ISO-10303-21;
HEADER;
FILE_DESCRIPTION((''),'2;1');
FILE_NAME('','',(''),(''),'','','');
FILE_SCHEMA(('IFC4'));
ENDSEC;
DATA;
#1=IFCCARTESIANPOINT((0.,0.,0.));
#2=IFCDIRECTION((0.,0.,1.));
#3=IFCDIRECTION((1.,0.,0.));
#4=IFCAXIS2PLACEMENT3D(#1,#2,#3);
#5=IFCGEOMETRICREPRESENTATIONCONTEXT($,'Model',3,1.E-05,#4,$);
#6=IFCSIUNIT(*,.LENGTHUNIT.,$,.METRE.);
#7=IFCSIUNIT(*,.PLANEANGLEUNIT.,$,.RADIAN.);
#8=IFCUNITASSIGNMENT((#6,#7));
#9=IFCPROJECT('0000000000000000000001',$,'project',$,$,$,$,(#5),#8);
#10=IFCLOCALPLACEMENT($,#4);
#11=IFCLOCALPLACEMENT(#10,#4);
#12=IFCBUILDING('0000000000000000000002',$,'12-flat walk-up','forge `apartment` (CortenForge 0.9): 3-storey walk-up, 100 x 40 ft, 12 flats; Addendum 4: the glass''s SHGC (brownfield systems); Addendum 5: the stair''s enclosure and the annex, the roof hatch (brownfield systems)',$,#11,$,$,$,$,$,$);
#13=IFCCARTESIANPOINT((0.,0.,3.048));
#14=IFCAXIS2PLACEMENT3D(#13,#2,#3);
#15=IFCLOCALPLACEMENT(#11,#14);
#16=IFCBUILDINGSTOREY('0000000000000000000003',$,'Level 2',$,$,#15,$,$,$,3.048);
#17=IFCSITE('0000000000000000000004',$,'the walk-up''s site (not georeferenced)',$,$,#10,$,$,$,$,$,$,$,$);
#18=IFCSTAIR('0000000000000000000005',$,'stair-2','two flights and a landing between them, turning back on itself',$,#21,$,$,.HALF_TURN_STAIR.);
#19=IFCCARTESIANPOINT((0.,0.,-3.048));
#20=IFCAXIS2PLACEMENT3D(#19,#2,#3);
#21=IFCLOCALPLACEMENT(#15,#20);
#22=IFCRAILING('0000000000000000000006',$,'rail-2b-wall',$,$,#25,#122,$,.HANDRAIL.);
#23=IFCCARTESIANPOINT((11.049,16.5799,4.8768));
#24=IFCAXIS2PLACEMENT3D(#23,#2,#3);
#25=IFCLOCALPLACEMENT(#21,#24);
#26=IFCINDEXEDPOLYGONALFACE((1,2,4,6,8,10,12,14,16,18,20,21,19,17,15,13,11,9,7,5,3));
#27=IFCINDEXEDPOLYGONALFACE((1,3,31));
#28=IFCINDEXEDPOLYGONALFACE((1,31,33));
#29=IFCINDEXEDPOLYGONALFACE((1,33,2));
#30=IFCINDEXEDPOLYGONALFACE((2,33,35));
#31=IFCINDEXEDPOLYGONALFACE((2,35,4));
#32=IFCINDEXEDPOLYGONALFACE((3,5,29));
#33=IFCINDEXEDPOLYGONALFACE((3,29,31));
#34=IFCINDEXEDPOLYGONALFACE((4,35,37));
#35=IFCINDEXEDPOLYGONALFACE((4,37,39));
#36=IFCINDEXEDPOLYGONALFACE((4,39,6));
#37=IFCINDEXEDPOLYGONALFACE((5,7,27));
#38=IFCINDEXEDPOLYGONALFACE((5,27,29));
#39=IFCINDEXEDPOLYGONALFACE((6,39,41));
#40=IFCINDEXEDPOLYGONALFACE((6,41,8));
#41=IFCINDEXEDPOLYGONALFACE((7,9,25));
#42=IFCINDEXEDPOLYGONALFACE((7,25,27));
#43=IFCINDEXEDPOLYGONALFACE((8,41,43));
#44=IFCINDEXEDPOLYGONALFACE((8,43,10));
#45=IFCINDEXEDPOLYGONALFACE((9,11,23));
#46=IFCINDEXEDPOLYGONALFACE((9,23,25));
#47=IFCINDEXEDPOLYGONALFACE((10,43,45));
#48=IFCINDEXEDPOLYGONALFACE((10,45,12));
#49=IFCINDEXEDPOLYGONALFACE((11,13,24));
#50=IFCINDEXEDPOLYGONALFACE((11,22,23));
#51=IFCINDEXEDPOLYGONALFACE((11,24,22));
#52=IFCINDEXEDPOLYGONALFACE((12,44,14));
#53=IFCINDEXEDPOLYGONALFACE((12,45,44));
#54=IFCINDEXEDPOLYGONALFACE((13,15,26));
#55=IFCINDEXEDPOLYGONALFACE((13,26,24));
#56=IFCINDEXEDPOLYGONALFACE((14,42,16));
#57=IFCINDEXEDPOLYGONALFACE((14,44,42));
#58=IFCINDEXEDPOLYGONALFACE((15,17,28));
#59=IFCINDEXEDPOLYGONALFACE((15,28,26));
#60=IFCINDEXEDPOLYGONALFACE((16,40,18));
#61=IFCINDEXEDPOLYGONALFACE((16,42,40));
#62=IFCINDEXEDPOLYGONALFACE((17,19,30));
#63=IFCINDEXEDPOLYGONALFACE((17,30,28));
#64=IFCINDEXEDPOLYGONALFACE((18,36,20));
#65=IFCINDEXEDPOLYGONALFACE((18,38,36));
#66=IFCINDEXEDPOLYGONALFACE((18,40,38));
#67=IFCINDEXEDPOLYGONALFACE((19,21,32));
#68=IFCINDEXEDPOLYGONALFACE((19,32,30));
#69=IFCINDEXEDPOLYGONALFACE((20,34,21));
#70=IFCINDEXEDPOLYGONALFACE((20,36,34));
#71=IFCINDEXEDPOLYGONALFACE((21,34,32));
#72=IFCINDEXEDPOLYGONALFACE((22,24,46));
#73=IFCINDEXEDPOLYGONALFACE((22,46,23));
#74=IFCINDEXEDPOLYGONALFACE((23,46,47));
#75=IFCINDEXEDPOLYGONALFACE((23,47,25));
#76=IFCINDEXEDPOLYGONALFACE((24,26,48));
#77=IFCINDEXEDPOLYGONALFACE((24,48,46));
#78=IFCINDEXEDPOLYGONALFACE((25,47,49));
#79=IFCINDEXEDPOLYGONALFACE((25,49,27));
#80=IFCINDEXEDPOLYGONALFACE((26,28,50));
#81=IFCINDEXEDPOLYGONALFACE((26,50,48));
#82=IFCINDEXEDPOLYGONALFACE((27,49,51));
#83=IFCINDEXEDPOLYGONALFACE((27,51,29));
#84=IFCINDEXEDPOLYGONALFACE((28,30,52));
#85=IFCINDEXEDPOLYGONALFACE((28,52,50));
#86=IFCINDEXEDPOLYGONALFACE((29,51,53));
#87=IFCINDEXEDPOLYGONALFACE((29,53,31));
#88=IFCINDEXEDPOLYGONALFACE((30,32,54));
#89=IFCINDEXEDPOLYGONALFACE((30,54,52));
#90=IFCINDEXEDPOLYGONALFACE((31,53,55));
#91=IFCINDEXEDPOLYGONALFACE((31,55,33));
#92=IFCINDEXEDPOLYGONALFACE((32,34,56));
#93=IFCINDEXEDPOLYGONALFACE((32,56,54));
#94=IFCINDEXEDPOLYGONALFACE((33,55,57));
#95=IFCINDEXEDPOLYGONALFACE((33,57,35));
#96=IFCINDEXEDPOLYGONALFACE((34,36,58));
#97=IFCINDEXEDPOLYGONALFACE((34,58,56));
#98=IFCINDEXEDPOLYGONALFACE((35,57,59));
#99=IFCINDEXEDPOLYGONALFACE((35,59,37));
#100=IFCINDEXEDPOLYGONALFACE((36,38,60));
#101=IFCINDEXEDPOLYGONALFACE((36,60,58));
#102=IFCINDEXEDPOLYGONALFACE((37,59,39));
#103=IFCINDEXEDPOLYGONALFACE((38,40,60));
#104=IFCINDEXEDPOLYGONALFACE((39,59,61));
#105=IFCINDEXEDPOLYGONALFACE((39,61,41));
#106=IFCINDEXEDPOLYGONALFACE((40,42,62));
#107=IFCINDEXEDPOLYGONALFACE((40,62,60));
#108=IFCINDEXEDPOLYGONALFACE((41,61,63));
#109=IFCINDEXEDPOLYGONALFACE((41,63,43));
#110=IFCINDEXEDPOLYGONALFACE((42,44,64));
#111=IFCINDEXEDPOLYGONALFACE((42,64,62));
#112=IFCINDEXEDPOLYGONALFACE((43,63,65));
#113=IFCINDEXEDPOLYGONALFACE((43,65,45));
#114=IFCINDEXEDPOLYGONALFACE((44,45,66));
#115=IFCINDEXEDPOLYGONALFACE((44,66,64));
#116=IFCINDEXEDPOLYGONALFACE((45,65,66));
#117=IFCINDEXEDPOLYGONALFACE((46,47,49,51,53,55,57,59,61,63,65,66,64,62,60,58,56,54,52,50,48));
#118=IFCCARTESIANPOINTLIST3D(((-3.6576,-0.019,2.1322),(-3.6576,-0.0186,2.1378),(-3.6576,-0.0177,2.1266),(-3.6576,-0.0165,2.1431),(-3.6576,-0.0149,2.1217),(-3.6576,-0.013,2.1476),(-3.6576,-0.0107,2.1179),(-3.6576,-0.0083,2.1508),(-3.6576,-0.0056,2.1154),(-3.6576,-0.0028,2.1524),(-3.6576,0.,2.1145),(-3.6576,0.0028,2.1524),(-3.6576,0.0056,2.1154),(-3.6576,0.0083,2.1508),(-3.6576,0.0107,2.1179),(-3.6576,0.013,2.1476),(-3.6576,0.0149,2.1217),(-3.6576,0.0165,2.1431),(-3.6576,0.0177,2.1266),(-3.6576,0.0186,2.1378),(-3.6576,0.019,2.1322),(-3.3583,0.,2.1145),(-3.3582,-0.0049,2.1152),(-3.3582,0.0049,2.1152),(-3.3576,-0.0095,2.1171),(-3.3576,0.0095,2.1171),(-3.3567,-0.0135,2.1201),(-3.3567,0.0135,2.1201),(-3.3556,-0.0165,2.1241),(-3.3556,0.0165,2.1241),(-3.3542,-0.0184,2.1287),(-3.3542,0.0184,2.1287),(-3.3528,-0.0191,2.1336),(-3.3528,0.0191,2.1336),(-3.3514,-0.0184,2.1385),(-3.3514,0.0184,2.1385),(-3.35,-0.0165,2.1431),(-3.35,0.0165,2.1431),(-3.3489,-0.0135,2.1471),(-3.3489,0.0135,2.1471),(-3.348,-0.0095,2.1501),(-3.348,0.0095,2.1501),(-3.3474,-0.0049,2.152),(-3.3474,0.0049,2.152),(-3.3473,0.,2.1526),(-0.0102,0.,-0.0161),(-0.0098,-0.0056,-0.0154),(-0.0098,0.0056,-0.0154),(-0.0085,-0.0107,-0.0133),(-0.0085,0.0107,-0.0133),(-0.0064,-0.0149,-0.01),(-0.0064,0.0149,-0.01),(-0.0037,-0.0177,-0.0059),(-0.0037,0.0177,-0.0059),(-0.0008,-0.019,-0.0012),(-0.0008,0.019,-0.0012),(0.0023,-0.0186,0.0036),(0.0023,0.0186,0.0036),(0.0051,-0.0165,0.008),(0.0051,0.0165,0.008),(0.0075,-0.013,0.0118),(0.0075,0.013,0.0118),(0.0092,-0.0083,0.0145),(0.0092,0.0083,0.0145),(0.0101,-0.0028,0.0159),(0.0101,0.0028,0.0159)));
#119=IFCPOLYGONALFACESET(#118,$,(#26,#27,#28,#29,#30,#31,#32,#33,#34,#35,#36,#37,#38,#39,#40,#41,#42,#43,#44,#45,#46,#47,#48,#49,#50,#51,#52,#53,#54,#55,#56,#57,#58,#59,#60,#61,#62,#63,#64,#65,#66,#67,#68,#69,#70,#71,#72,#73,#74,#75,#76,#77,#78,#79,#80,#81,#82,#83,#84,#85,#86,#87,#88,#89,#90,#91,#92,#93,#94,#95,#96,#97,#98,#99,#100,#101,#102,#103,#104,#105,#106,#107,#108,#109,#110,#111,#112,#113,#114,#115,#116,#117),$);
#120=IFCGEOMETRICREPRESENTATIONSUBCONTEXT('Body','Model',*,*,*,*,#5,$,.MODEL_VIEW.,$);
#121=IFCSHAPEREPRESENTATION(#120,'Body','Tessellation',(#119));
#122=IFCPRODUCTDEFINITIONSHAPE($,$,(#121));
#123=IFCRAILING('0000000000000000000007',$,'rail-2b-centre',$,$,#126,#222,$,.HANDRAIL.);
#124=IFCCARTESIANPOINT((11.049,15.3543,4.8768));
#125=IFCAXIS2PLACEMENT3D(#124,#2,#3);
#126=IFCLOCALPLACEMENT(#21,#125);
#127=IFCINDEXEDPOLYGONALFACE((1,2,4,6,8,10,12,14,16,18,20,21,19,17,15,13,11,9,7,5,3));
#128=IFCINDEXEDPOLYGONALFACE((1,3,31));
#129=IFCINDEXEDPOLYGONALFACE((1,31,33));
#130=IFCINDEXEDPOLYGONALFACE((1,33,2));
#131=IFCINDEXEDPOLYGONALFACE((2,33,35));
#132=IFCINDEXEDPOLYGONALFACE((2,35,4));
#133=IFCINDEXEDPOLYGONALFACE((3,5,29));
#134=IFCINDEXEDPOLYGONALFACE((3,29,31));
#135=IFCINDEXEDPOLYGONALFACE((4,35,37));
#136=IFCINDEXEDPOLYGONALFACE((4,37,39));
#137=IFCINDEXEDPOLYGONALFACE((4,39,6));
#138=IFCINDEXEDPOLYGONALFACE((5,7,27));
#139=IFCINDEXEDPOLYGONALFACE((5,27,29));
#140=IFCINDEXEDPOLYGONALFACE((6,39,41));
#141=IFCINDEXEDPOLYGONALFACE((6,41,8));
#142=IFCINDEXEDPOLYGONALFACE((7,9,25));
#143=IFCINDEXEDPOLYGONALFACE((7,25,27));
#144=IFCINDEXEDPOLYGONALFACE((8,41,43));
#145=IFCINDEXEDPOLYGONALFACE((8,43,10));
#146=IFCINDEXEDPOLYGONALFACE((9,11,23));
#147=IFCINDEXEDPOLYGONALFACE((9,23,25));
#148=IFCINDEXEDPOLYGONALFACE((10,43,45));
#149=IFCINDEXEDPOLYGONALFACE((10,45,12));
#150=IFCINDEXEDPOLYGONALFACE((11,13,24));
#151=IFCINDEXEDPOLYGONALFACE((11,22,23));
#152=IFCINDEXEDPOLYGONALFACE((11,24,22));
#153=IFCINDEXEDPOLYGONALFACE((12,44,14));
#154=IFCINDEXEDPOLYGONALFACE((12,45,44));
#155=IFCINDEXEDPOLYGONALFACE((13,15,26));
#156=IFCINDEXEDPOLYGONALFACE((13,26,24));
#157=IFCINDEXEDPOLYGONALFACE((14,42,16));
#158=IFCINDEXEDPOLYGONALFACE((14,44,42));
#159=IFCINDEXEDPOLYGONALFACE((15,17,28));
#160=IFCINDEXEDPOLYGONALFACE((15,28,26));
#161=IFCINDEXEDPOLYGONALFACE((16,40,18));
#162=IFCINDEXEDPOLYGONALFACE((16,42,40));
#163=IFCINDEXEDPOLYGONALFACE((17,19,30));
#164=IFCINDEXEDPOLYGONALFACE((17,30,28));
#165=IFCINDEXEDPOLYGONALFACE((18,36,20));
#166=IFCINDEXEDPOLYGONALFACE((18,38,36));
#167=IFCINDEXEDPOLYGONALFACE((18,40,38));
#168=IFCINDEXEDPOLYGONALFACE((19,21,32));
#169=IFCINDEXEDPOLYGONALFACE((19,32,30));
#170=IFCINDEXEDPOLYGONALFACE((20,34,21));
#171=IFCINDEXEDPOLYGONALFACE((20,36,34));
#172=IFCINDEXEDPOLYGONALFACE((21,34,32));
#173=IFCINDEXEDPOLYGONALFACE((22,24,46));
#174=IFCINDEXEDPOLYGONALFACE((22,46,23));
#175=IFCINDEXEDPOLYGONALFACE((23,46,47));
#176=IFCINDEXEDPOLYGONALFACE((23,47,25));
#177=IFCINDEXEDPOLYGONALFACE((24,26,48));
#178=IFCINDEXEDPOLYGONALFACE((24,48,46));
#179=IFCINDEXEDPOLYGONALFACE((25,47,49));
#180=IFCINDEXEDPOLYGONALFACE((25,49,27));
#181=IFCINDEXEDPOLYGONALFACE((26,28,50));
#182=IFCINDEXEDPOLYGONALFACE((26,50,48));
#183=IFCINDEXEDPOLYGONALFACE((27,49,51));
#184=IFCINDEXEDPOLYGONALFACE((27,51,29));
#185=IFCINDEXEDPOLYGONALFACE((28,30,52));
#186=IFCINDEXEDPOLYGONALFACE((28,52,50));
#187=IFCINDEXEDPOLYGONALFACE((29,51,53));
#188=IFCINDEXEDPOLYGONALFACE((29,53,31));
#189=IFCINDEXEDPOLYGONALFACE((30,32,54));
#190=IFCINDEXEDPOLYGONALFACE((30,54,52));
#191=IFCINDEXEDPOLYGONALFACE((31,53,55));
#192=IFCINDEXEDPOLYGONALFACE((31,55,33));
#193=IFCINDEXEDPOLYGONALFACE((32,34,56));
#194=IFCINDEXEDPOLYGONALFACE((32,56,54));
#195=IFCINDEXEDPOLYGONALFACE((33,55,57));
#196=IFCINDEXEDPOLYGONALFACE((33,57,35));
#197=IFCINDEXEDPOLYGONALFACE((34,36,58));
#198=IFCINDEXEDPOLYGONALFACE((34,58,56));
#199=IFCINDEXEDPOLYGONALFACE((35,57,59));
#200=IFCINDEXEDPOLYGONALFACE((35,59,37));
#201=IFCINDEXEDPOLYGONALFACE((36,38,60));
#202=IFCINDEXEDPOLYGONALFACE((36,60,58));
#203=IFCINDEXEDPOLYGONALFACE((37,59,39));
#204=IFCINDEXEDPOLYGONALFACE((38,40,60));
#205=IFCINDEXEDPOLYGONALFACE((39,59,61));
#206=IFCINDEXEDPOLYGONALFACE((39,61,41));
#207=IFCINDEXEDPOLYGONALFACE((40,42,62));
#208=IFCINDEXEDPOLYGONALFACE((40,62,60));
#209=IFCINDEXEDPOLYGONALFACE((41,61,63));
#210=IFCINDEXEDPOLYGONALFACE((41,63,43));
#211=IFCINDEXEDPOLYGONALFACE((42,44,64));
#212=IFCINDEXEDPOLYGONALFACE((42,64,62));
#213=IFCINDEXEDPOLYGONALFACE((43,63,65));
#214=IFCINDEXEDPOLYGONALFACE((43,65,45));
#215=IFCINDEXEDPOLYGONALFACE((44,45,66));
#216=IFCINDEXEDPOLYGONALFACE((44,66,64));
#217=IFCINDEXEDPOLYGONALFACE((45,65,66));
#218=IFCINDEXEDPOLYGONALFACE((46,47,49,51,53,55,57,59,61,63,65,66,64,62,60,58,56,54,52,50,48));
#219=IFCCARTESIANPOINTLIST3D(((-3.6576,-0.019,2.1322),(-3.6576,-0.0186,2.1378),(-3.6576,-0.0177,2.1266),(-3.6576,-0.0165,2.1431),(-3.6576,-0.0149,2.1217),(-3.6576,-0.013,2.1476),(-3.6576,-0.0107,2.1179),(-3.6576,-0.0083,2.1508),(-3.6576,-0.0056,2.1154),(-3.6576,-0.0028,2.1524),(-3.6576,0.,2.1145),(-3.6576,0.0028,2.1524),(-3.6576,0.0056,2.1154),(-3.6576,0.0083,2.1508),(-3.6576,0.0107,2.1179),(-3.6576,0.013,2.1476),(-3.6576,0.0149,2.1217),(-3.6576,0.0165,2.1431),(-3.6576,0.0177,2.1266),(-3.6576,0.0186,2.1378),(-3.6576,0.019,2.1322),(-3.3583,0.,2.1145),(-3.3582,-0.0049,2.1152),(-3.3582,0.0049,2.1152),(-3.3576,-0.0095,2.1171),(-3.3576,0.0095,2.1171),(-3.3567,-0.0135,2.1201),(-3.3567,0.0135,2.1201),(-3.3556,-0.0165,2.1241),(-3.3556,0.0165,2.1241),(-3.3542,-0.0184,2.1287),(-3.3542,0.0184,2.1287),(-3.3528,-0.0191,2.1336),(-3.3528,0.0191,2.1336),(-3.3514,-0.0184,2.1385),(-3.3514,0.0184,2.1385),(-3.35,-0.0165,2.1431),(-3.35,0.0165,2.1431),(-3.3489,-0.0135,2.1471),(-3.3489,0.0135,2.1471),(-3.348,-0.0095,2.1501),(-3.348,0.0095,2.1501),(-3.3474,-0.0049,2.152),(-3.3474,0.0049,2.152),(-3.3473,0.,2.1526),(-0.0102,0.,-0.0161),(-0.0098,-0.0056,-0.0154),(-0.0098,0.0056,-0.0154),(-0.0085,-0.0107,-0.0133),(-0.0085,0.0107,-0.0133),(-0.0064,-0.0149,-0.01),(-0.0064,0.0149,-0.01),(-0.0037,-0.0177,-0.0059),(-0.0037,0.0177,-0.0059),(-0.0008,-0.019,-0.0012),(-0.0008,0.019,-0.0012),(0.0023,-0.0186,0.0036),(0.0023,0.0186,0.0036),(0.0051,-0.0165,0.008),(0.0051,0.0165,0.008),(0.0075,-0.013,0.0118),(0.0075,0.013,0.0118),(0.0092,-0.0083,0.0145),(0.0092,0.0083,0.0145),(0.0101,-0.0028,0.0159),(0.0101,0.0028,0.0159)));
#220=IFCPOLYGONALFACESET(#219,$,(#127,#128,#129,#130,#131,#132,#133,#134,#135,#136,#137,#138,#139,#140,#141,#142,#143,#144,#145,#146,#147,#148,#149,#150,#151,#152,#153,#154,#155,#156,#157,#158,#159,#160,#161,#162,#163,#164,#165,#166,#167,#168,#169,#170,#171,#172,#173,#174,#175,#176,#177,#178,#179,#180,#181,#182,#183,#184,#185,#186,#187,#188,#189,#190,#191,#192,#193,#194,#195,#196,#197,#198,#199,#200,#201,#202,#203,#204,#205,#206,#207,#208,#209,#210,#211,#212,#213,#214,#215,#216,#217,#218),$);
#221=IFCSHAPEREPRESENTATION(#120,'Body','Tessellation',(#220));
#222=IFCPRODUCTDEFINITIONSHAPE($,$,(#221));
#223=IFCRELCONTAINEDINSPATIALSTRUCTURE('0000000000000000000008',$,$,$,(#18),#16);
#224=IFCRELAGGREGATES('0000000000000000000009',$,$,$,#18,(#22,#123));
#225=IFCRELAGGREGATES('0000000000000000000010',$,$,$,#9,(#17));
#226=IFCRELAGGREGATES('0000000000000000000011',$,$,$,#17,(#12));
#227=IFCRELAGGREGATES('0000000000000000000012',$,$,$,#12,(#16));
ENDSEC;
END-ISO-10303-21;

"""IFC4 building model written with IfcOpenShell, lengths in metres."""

from ifc_helpers import new_model, entity, si_unit, frame, origin_with_axes, place, context, subcontext, project, spatial, element, aggregate, save


model = new_model("IFC4")

# Units and contexts
model_context = context("Model", 3, precision=1e-05, world=origin_with_axes())
body_context = subcontext(model_context, "Body", "Model", "MODEL_VIEW")
ifc_project = project(units=[si_unit("LENGTHUNIT", "METRE"), si_unit("PLANEANGLEUNIT", "RADIAN")], contexts=[model_context])

# Site, building, storey
site_placement = place(None, origin_with_axes())
site = spatial("IfcSite", under=ifc_project, at=site_placement, Name="the walk-up's site (not georeferenced)")
building_placement = place(site_placement, origin_with_axes())
building = spatial("IfcBuilding", under=site, at=building_placement, Name="12-flat walk-up", Description="forge `apartment` (CortenForge 0.9): 3-storey walk-up, 100 x 40 ft, 12 flats; Addendum 4: the glass's SHGC (brownfield systems); Addendum 5: the stair's enclosure and the annex, the roof hatch (brownfield systems)")
storey_placement = place(building_placement, frame((0.0, 0.0, 3.048), z_axis=(0.0, 0.0, 1.0), x_axis=(1.0, 0.0, 0.0)))
storey = spatial("IfcBuildingStorey", under=building, at=storey_placement, Name="Level 2", Elevation=3.048)

# Stair, railings
stair_placement = place(storey_placement, frame((0.0, 0.0, -3.048), z_axis=(0.0, 0.0, 1.0), x_axis=(1.0, 0.0, 0.0)))
stair = element("IfcStair", 1, at=stair_placement, inside=storey, Name="stair-2", Description="two flights and a landing between them, turning back on itself", PredefinedType="HALF_TURN_STAIR")
railing_1_placement = place(stair_placement, frame((11.049, 16.5799, 4.8768), z_axis=(0.0, 0.0, 1.0), x_axis=(1.0, 0.0, 0.0)))
railing_1 = element("IfcRailing", 2, at=railing_1_placement, Name="rail-2b-wall", PredefinedType="HANDRAIL", context=body_context, shape_type="AdvancedSweptSolid", body=[
    entity("IfcSweptDiskSolid", entity("IfcPolyline", [entity("IfcCartesianPoint", [0.0, 0.0, 0.0]), entity("IfcCartesianPoint", [-3.3528, 0.0, 2.1336]), entity("IfcCartesianPoint", [-3.6576, 0.0, 2.1336])]), 0.0191),
])
railing_2_placement = place(stair_placement, frame((11.049, 15.3543, 4.8768), z_axis=(0.0, 0.0, 1.0), x_axis=(1.0, 0.0, 0.0)))
railing_2 = element("IfcRailing", 3, at=railing_2_placement, Name="rail-2b-centre", PredefinedType="HANDRAIL", context=body_context, shape_type="AdvancedSweptSolid", body=[
    entity("IfcSweptDiskSolid", entity("IfcPolyline", [entity("IfcCartesianPoint", [0.0, 0.0, 0.0]), entity("IfcCartesianPoint", [-3.3528, 0.0, 2.1336]), entity("IfcCartesianPoint", [-3.6576, 0.0, 2.1336])]), 0.0191),
])
aggregate(stair, [railing_1, railing_2])

save(model, "model.ifc")
